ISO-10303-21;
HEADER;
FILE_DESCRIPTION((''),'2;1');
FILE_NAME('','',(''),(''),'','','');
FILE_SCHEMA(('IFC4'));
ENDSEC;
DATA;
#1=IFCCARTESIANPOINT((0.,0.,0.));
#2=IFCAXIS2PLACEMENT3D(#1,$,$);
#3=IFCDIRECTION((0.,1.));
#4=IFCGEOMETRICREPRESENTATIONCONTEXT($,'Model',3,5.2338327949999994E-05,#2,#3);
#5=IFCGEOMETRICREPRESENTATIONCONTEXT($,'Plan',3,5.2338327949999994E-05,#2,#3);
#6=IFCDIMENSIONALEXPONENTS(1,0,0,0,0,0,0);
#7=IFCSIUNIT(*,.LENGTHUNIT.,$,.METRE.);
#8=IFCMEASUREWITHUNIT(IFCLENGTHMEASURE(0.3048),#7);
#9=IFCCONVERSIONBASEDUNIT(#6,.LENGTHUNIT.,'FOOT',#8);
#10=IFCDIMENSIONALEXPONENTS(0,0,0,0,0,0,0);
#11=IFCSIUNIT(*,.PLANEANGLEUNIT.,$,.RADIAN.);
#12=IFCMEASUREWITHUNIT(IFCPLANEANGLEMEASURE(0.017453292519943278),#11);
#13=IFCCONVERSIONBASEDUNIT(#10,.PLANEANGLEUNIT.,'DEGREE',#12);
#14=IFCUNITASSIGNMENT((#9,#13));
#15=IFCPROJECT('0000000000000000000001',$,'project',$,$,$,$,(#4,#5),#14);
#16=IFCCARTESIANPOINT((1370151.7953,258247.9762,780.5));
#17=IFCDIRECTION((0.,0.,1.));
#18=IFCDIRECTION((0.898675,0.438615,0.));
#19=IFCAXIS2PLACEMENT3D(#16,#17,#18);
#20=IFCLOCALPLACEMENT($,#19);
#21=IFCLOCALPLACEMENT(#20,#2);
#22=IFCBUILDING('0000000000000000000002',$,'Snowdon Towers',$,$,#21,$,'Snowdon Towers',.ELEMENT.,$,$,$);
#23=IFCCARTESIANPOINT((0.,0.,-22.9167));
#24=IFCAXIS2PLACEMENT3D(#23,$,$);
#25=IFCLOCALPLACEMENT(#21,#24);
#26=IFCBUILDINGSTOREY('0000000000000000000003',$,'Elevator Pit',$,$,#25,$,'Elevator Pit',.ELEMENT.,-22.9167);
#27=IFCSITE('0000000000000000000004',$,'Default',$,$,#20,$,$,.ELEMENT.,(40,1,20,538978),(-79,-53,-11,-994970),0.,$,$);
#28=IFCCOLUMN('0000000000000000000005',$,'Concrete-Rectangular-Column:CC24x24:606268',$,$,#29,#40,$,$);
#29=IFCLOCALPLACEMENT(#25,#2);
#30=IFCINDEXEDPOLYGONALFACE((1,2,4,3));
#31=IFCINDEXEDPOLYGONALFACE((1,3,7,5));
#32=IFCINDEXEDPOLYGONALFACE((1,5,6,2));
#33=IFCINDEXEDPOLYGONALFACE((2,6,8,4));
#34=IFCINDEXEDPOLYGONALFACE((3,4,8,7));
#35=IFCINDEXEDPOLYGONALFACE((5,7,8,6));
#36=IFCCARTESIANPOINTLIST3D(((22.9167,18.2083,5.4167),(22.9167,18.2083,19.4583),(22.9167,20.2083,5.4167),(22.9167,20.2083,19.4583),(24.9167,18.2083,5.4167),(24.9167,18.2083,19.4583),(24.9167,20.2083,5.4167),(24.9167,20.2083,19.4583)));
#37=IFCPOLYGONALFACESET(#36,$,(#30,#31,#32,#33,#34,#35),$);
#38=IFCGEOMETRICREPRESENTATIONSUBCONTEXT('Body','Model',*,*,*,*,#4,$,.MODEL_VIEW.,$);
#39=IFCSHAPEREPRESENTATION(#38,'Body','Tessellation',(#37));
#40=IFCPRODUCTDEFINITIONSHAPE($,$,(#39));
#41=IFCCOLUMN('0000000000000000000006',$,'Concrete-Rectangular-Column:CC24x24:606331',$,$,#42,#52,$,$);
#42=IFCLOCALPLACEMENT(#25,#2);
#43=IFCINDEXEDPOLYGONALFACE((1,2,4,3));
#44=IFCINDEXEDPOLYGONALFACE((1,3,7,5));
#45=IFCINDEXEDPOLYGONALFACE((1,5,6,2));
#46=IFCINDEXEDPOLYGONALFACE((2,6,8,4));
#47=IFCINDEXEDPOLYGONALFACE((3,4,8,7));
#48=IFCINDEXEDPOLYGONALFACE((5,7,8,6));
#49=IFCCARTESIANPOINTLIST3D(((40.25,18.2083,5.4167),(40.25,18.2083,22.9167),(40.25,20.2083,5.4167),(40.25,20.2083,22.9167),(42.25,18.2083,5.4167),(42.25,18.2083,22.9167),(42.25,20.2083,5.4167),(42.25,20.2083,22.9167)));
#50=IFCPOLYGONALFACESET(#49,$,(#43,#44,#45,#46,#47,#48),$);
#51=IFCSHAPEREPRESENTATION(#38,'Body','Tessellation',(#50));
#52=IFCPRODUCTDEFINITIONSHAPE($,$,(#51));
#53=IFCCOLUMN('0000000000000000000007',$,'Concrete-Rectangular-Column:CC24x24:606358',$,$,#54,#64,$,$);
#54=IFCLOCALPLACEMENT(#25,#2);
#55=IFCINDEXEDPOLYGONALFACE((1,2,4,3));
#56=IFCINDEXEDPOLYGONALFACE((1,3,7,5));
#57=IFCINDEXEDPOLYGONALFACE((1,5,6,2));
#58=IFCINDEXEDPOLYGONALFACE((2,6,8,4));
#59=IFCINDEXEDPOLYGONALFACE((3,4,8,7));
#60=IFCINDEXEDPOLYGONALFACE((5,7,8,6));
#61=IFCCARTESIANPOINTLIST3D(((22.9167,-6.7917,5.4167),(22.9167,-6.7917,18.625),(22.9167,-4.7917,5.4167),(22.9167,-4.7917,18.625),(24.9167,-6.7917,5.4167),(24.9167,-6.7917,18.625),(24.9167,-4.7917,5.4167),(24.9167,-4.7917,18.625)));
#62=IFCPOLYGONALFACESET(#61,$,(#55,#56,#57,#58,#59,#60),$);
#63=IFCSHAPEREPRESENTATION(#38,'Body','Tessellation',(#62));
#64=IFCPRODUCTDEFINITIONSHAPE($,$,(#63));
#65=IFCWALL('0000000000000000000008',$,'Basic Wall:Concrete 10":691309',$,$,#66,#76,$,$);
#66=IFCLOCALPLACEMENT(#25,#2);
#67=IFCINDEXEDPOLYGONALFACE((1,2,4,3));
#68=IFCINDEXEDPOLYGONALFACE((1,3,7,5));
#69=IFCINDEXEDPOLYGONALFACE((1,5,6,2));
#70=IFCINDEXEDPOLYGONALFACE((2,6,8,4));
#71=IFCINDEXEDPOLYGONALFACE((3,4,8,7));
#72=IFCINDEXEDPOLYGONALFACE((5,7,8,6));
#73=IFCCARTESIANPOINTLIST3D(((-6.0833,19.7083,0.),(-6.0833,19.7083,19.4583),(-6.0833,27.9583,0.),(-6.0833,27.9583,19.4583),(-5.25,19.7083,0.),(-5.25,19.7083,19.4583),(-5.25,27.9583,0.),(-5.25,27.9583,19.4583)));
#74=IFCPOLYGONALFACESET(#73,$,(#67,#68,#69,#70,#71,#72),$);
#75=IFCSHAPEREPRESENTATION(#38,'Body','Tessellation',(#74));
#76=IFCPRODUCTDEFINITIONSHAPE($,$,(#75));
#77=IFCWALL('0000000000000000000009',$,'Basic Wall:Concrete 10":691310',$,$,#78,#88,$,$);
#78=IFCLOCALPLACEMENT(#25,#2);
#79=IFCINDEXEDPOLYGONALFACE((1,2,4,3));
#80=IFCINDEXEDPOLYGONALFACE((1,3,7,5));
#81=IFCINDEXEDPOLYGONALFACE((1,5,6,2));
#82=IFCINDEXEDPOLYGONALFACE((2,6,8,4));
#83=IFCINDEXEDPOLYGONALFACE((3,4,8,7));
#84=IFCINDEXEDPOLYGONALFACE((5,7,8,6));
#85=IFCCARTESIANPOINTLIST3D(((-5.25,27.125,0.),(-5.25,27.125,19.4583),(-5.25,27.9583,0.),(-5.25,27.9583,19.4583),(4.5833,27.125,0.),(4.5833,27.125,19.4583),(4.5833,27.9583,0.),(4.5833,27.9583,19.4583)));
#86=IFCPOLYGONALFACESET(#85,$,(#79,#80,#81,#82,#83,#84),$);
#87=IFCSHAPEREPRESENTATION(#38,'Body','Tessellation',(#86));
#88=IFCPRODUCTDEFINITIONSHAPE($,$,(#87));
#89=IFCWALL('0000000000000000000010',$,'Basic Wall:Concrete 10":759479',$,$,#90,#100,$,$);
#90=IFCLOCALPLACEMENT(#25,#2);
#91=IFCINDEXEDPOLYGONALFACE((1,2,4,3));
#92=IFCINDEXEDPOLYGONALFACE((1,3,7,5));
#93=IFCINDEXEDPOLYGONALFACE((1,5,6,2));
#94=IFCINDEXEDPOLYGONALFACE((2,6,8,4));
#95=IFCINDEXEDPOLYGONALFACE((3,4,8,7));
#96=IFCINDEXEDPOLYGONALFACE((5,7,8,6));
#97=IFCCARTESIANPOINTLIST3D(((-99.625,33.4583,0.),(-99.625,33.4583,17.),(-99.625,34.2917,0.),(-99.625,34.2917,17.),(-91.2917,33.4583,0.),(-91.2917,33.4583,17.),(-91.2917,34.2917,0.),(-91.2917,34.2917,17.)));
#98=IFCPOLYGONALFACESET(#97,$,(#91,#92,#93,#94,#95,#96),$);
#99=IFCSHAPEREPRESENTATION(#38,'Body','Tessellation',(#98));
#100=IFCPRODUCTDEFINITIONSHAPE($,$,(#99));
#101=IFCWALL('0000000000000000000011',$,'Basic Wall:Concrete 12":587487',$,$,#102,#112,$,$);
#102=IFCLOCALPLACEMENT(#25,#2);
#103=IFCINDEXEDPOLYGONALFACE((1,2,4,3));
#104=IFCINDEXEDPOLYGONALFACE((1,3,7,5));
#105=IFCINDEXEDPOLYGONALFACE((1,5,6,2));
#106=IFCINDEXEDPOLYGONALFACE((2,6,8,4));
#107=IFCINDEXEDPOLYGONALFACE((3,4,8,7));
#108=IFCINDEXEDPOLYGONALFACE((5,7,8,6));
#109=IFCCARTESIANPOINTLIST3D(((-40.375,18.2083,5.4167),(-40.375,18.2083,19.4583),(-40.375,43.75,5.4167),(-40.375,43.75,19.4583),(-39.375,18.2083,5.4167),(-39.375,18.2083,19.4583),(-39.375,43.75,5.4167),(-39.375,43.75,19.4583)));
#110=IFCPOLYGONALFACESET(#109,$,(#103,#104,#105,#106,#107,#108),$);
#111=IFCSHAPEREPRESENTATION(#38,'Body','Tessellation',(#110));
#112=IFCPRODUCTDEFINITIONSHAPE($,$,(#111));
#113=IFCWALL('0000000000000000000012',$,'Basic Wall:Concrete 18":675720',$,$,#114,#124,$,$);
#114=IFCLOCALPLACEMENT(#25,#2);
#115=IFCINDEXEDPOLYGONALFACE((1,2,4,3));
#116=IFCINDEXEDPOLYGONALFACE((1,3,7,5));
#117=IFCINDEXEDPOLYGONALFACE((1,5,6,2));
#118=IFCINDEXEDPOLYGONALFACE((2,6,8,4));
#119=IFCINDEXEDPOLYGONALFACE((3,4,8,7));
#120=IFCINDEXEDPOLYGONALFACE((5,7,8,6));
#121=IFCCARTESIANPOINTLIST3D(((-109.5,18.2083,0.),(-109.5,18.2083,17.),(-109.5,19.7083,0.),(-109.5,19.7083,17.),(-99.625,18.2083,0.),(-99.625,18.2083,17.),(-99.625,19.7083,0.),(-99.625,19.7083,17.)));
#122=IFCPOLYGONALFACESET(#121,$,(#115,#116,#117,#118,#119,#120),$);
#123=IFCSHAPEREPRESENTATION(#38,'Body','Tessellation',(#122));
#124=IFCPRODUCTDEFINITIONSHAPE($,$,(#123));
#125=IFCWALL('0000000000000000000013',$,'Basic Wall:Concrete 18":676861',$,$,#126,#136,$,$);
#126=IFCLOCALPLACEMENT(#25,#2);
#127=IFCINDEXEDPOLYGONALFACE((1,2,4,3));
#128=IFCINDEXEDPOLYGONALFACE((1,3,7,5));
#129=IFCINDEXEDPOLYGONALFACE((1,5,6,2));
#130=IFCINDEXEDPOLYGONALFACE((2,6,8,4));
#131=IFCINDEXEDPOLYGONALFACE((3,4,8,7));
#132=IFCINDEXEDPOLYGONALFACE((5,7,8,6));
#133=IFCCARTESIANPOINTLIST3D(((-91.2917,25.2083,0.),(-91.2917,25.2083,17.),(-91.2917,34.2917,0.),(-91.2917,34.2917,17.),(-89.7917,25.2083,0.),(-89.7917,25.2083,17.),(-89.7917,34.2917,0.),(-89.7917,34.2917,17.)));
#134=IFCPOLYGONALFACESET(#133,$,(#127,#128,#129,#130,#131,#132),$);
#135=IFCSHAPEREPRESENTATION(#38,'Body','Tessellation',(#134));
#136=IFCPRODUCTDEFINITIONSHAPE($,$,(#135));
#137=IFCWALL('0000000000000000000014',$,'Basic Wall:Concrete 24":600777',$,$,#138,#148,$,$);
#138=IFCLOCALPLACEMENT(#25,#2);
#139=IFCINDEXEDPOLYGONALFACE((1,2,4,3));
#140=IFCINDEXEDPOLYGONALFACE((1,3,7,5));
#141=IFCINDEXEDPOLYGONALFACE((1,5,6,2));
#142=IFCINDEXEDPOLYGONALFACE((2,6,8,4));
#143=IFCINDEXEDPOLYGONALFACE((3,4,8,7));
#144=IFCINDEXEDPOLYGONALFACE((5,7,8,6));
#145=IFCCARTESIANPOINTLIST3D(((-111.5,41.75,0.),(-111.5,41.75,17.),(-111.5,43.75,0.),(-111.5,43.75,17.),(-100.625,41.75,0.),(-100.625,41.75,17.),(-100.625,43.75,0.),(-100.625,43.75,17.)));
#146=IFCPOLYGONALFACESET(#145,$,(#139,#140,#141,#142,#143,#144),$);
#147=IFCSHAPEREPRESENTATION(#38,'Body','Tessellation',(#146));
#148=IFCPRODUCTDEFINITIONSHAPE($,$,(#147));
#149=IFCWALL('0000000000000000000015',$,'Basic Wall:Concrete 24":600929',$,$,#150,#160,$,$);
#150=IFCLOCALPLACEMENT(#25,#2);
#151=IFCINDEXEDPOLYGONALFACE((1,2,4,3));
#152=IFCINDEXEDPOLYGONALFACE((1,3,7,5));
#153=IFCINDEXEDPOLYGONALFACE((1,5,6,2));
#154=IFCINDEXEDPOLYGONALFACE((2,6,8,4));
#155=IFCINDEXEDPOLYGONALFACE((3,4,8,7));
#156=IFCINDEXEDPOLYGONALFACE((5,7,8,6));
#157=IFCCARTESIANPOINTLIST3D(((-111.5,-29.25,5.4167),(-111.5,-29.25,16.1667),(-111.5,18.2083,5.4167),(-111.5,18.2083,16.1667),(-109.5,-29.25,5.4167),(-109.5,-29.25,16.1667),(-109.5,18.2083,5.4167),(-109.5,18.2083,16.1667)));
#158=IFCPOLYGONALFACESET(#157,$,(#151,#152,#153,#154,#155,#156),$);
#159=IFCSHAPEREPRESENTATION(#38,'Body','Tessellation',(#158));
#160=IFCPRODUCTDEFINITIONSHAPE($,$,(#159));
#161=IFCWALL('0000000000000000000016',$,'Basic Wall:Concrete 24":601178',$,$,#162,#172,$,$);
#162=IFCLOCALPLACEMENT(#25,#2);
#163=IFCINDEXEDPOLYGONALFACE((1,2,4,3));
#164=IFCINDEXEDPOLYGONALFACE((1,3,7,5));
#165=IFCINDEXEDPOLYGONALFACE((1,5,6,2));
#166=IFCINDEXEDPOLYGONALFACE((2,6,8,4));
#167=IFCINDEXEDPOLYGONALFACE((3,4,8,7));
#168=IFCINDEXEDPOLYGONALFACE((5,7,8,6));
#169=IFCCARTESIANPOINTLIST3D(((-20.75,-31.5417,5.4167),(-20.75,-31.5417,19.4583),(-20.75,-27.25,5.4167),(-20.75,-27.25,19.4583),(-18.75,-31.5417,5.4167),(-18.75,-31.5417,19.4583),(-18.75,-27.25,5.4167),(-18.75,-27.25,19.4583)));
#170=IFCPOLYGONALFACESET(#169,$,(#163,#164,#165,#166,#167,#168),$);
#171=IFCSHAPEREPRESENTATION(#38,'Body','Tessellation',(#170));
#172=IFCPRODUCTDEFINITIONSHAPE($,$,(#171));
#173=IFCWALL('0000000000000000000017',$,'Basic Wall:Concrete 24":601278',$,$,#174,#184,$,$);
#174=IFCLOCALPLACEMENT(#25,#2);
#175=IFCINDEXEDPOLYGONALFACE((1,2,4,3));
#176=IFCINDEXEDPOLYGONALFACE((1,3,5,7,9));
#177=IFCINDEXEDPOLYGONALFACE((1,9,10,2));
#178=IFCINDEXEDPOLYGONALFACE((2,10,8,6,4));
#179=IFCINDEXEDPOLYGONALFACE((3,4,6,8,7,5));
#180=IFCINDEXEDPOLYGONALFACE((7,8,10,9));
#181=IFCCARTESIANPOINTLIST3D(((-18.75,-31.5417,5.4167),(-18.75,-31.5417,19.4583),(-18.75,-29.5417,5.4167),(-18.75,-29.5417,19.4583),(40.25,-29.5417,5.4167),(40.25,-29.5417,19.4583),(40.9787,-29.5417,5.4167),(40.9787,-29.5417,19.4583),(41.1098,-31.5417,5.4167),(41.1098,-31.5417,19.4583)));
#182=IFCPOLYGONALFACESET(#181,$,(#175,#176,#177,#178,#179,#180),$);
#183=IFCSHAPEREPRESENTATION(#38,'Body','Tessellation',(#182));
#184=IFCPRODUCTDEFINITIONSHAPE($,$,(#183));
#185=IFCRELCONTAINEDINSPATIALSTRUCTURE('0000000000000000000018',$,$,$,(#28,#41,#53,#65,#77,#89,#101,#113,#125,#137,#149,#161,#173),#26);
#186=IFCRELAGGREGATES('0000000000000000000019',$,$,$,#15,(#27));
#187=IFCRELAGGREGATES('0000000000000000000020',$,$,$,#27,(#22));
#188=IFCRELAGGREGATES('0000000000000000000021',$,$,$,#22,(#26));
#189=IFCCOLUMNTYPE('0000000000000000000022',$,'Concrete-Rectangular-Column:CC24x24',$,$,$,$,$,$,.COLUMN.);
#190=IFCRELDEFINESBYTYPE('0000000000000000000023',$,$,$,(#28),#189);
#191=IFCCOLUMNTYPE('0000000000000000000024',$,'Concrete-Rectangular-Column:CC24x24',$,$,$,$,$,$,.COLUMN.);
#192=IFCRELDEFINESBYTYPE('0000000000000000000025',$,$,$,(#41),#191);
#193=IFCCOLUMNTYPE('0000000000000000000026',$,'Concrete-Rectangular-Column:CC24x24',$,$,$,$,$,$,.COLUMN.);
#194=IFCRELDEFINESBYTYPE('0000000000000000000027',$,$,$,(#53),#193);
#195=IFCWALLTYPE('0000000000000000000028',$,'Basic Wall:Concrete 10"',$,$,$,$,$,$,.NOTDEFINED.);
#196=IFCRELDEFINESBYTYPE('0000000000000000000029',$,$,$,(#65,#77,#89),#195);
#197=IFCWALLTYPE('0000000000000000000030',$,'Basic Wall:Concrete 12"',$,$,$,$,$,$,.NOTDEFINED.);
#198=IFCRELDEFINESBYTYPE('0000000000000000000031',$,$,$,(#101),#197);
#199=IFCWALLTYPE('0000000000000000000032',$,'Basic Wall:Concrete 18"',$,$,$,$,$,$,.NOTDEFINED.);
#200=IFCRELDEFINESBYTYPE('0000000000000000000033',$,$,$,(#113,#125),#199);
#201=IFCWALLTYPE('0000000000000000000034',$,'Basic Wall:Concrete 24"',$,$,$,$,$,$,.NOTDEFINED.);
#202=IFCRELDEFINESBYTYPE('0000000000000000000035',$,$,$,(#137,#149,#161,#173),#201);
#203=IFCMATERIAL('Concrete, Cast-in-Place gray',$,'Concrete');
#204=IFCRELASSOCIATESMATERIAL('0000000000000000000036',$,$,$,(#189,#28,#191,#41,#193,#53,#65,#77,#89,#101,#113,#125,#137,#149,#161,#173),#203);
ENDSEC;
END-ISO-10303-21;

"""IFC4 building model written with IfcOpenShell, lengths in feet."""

from ifc_helpers import new_model, entity, si_unit, converted_unit, direction, frame, origin, place, context, subcontext, project, spatial, indexed_curve, outline, extrude, source, transform, mapped, material, type_object, type_shapes, element, save


model = new_model("IFC4")

# Units and contexts
model_context = context("Model", 3, precision=5.2338327949999994e-05, world=origin(), true_north=direction((0.0, 1.0)))
plan_context = context("Plan", 3, precision=5.2338327949999994e-05, world=origin(), true_north=direction((0.0, 1.0)))
body_context = subcontext(model_context, "Body", "Model", "MODEL_VIEW")
ifc_project = project(units=[converted_unit("LENGTHUNIT", "FOOT", entity("IfcLengthMeasure", 0.3048), si_unit("LENGTHUNIT", "METRE"), dimensions=[1, 0, 0, 0, 0, 0, 0]), converted_unit("PLANEANGLEUNIT", "DEGREE", entity("IfcPlaneAngleMeasure", 0.017453292519943278), si_unit("PLANEANGLEUNIT", "RADIAN"), dimensions=[0, 0, 0, 0, 0, 0, 0])], contexts=[model_context, plan_context])

# Site, building, storey
site_placement = place(None, frame((1370151.7953, 258247.9762, 780.5), z_axis=(0.0, 0.0, 1.0), x_axis=(0.898675, 0.438615, 0.0)))
site = spatial("IfcSite", under=ifc_project, at=site_placement, Name="Default", CompositionType="ELEMENT", RefLatitude=(40, 1, 20, 538978), RefLongitude=(-79, -53, -11, -994970), RefElevation=0.0)
building_placement = place(site_placement, origin())
building = spatial("IfcBuilding", under=site, at=building_placement, Name="Snowdon Towers", LongName="Snowdon Towers", CompositionType="ELEMENT")
storey_placement = place(building_placement, frame((0.0, 0.0, -22.9167)))
storey = spatial("IfcBuildingStorey", under=building, at=storey_placement, Name="Elevator Pit", LongName="Elevator Pit", CompositionType="ELEMENT", Elevation=-22.9167)

# Columns
ifc_material = material(Name="Concrete, Cast-in-Place gray", Category="Concrete")
column_type_1 = type_object("IfcColumnType", Name="Concrete-Rectangular-Column:CC24x24", PredefinedType="COLUMN", material=ifc_material)
shared_shape_1 = source(origin(), body_context, "Body", "SweptSolid", [
    extrude(outline(indexed_curve([(-1.0, -1.0), (1.0, -1.0), (1.0, 1.0), (-1.0, 1.0), (-1.0, -1.0)], self_intersect=False)), frame((23.9167, 19.2083, -17.5), z_axis=(0.0, 0.0, 1.0), x_axis=(-1.0, 0.0, 0.0)), (0.0, 0.0, 1.0), 14.0417),
])
type_shapes(column_type_1, [shared_shape_1])
column_1_placement = place(storey_placement, frame((0.0, 0.0, 22.9167)))
element("IfcColumn", 1, at=column_1_placement, inside=storey, type_object=column_type_1, material=ifc_material, Name="Concrete-Rectangular-Column:CC24x24:606268", context=body_context, shape_type="MappedRepresentation", body=[
    mapped(shared_shape_1, transform((0.0, 0.0, 0.0), scale=1.0)),
])
column_type_2 = type_object("IfcColumnType", Name="Concrete-Rectangular-Column:CC24x24", PredefinedType="COLUMN", material=ifc_material)
shared_shape_2 = source(origin(), body_context, "Body", "SweptSolid", [
    extrude(outline(indexed_curve([(-1.0, -1.0), (1.0, -1.0), (1.0, 1.0), (-1.0, 1.0), (-1.0, -1.0)], self_intersect=False)), frame((41.25, 19.2083, -17.5), z_axis=(0.0, 0.0, 1.0), x_axis=(-1.0, 0.0, 0.0)), (0.0, 0.0, 1.0), 17.5),
])
type_shapes(column_type_2, [shared_shape_2])
column_2_placement = place(storey_placement, frame((0.0, 0.0, 22.9167)))
element("IfcColumn", 2, at=column_2_placement, inside=storey, type_object=column_type_2, material=ifc_material, Name="Concrete-Rectangular-Column:CC24x24:606331", context=body_context, shape_type="MappedRepresentation", body=[
    mapped(shared_shape_2, transform((0.0, 0.0, 0.0), scale=1.0)),
])
column_type_3 = type_object("IfcColumnType", Name="Concrete-Rectangular-Column:CC24x24", PredefinedType="COLUMN", material=ifc_material)
shared_shape_3 = source(origin(), body_context, "Body", "SweptSolid", [
    extrude(outline(indexed_curve([(-1.0, -1.0), (1.0, -1.0), (1.0, 1.0), (-1.0, 1.0), (-1.0, -1.0)], self_intersect=False)), frame((23.9167, -5.7917, -17.5), z_axis=(0.0, 0.0, 1.0), x_axis=(-1.0, 0.0, 0.0)), (0.0, 0.0, 1.0), 13.2083),
])
type_shapes(column_type_3, [shared_shape_3])
column_3_placement = place(storey_placement, frame((0.0, 0.0, 22.9167)))
element("IfcColumn", 3, at=column_3_placement, inside=storey, type_object=column_type_3, material=ifc_material, Name="Concrete-Rectangular-Column:CC24x24:606358", context=body_context, shape_type="MappedRepresentation", body=[
    mapped(shared_shape_3, transform((0.0, 0.0, 0.0), scale=1.0)),
])

# Walls
wall_type_1 = type_object("IfcWallType", Name="Basic Wall:Concrete 10\"", PredefinedType="NOTDEFINED")
wall_1_placement = place(storey_placement, frame((-5.6667, 27.9583, 0.0), z_axis=(0.0, 0.0, 1.0), x_axis=(0.0, -1.0, 0.0)))
element("IfcWall", 4, at=wall_1_placement, inside=storey, type_object=wall_type_1, material=ifc_material, Name="Basic Wall:Concrete 10\":691309", context=body_context, shape_type="SweptSolid", body=[
    extrude(outline(indexed_curve([(8.25, 0.4167), (0.0, 0.4167), (0.0, -0.4167), (8.25, -0.4167), (8.25, 0.4167)], self_intersect=False)), origin(), (0.0, 0.0, 1.0), 19.4583),
])
wall_2_placement = place(storey_placement, frame((4.5833, 27.5417, 0.0), z_axis=(0.0, 0.0, 1.0), x_axis=(-1.0, 0.0, 0.0)))
element("IfcWall", 5, at=wall_2_placement, inside=storey, type_object=wall_type_1, material=ifc_material, Name="Basic Wall:Concrete 10\":691310", context=body_context, shape_type="SweptSolid", body=[
    extrude(outline(indexed_curve([(9.8333, 0.4167), (0.0, 0.4167), (0.0, -0.4167), (9.8333, -0.4167), (9.8333, 0.4167)], self_intersect=False)), origin(), (0.0, 0.0, 1.0), 19.4583),
])
wall_3_placement = place(storey_placement, frame((-99.625, 33.875, 0.0)))
element("IfcWall", 6, at=wall_3_placement, inside=storey, type_object=wall_type_1, material=ifc_material, Name="Basic Wall:Concrete 10\":759479", context=body_context, shape_type="SweptSolid", body=[
    extrude(outline(indexed_curve([(8.3333, 0.4167), (0.0, 0.4167), (0.0, -0.4167), (8.3333, -0.4167), (8.3333, 0.4167)], self_intersect=False)), origin(), (0.0, 0.0, 1.0), 17.0),
])
wall_type_2 = type_object("IfcWallType", Name="Basic Wall:Concrete 12\"", PredefinedType="NOTDEFINED")
wall_4_placement = place(storey_placement, frame((-39.875, 18.2083, 5.4167), z_axis=(0.0, 0.0, 1.0), x_axis=(0.0, 1.0, 0.0)))
element("IfcWall", 7, at=wall_4_placement, inside=storey, type_object=wall_type_2, material=ifc_material, Name="Basic Wall:Concrete 12\":587487", context=body_context, shape_type="SweptSolid", body=[
    extrude(outline(indexed_curve([(25.5417, 0.5), (0.0, 0.5), (0.0, -0.5), (25.5417, -0.5), (25.5417, 0.5)], self_intersect=False)), origin(), (0.0, 0.0, 1.0), 14.0417),
])
wall_type_3 = type_object("IfcWallType", Name="Basic Wall:Concrete 18\"", PredefinedType="NOTDEFINED")
wall_5_placement = place(storey_placement, frame((-99.625, 18.9583, 0.0), z_axis=(0.0, 0.0, 1.0), x_axis=(-1.0, 0.0, 0.0)))
element("IfcWall", 8, at=wall_5_placement, inside=storey, type_object=wall_type_3, material=ifc_material, Name="Basic Wall:Concrete 18\":675720", context=body_context, shape_type="SweptSolid", body=[
    extrude(outline(indexed_curve([(9.875, 0.75), (0.0, 0.75), (0.0, -0.75), (9.875, -0.75), (9.875, 0.75)], self_intersect=False)), origin(), (0.0, 0.0, 1.0), 17.0),
])
wall_6_placement = place(storey_placement, frame((-90.5417, 34.2917, 0.0), z_axis=(0.0, 0.0, 1.0), x_axis=(0.0, -1.0, 0.0)))
element("IfcWall", 9, at=wall_6_placement, inside=storey, type_object=wall_type_3, material=ifc_material, Name="Basic Wall:Concrete 18\":676861", context=body_context, shape_type="SweptSolid", body=[
    extrude(outline(indexed_curve([(9.0833, 0.75), (0.0, 0.75), (0.0, -0.75), (9.0833, -0.75), (9.0833, 0.75)], self_intersect=False)), origin(), (0.0, 0.0, 1.0), 17.0),
])
wall_type_4 = type_object("IfcWallType", Name="Basic Wall:Concrete 24\"", PredefinedType="NOTDEFINED")
wall_7_placement = place(storey_placement, frame((-111.5, 42.75, 0.0)))
element("IfcWall", 10, at=wall_7_placement, inside=storey, type_object=wall_type_4, material=ifc_material, Name="Basic Wall:Concrete 24\":600777", context=body_context, shape_type="SweptSolid", body=[
    extrude(outline(indexed_curve([(10.875, 1.0), (0.0, 1.0), (0.0, -1.0), (10.875, -1.0), (10.875, 1.0)], self_intersect=False)), origin(), (0.0, 0.0, 1.0), 17.0),
])
wall_8_placement = place(storey_placement, frame((-110.5, -29.25, 5.4167), z_axis=(0.0, 0.0, 1.0), x_axis=(0.0, 1.0, 0.0)))
element("IfcWall", 11, at=wall_8_placement, inside=storey, type_object=wall_type_4, material=ifc_material, Name="Basic Wall:Concrete 24\":600929", context=body_context, shape_type="SweptSolid", body=[
    extrude(outline(indexed_curve([(47.4583, 1.0), (0.0, 1.0), (0.0, -1.0), (47.4583, -1.0), (47.4583, 1.0)], self_intersect=False)), origin(), (0.0, 0.0, 1.0), 10.75),
])
wall_9_placement = place(storey_placement, frame((-19.75, -27.25, 5.4167), z_axis=(0.0, 0.0, 1.0), x_axis=(0.0, -1.0, 0.0)))
element("IfcWall", 12, at=wall_9_placement, inside=storey, type_object=wall_type_4, material=ifc_material, Name="Basic Wall:Concrete 24\":601178", context=body_context, shape_type="SweptSolid", body=[
    extrude(outline(indexed_curve([(4.2917, 1.0), (0.0, 1.0), (0.0, -1.0), (4.2917, -1.0), (4.2917, 1.0)], self_intersect=False)), origin(), (0.0, 0.0, 1.0), 14.0417),
])
wall_10_placement = place(storey_placement, frame((-18.75, -30.5417, 5.4167)))
element("IfcWall", 13, at=wall_10_placement, inside=storey, type_object=wall_type_4, material=ifc_material, Name="Basic Wall:Concrete 24\":601278", context=body_context, shape_type="SweptSolid", body=[
    extrude(outline(indexed_curve([(59.8598, -1.0), (59.7287, 1.0), (59.0, 1.0), (0.0, 1.0), (0.0, -1.0), (59.8598, -1.0)], self_intersect=False)), origin(), (0.0, 0.0, 1.0), 14.0417),
])

save(model, "model.ifc")
